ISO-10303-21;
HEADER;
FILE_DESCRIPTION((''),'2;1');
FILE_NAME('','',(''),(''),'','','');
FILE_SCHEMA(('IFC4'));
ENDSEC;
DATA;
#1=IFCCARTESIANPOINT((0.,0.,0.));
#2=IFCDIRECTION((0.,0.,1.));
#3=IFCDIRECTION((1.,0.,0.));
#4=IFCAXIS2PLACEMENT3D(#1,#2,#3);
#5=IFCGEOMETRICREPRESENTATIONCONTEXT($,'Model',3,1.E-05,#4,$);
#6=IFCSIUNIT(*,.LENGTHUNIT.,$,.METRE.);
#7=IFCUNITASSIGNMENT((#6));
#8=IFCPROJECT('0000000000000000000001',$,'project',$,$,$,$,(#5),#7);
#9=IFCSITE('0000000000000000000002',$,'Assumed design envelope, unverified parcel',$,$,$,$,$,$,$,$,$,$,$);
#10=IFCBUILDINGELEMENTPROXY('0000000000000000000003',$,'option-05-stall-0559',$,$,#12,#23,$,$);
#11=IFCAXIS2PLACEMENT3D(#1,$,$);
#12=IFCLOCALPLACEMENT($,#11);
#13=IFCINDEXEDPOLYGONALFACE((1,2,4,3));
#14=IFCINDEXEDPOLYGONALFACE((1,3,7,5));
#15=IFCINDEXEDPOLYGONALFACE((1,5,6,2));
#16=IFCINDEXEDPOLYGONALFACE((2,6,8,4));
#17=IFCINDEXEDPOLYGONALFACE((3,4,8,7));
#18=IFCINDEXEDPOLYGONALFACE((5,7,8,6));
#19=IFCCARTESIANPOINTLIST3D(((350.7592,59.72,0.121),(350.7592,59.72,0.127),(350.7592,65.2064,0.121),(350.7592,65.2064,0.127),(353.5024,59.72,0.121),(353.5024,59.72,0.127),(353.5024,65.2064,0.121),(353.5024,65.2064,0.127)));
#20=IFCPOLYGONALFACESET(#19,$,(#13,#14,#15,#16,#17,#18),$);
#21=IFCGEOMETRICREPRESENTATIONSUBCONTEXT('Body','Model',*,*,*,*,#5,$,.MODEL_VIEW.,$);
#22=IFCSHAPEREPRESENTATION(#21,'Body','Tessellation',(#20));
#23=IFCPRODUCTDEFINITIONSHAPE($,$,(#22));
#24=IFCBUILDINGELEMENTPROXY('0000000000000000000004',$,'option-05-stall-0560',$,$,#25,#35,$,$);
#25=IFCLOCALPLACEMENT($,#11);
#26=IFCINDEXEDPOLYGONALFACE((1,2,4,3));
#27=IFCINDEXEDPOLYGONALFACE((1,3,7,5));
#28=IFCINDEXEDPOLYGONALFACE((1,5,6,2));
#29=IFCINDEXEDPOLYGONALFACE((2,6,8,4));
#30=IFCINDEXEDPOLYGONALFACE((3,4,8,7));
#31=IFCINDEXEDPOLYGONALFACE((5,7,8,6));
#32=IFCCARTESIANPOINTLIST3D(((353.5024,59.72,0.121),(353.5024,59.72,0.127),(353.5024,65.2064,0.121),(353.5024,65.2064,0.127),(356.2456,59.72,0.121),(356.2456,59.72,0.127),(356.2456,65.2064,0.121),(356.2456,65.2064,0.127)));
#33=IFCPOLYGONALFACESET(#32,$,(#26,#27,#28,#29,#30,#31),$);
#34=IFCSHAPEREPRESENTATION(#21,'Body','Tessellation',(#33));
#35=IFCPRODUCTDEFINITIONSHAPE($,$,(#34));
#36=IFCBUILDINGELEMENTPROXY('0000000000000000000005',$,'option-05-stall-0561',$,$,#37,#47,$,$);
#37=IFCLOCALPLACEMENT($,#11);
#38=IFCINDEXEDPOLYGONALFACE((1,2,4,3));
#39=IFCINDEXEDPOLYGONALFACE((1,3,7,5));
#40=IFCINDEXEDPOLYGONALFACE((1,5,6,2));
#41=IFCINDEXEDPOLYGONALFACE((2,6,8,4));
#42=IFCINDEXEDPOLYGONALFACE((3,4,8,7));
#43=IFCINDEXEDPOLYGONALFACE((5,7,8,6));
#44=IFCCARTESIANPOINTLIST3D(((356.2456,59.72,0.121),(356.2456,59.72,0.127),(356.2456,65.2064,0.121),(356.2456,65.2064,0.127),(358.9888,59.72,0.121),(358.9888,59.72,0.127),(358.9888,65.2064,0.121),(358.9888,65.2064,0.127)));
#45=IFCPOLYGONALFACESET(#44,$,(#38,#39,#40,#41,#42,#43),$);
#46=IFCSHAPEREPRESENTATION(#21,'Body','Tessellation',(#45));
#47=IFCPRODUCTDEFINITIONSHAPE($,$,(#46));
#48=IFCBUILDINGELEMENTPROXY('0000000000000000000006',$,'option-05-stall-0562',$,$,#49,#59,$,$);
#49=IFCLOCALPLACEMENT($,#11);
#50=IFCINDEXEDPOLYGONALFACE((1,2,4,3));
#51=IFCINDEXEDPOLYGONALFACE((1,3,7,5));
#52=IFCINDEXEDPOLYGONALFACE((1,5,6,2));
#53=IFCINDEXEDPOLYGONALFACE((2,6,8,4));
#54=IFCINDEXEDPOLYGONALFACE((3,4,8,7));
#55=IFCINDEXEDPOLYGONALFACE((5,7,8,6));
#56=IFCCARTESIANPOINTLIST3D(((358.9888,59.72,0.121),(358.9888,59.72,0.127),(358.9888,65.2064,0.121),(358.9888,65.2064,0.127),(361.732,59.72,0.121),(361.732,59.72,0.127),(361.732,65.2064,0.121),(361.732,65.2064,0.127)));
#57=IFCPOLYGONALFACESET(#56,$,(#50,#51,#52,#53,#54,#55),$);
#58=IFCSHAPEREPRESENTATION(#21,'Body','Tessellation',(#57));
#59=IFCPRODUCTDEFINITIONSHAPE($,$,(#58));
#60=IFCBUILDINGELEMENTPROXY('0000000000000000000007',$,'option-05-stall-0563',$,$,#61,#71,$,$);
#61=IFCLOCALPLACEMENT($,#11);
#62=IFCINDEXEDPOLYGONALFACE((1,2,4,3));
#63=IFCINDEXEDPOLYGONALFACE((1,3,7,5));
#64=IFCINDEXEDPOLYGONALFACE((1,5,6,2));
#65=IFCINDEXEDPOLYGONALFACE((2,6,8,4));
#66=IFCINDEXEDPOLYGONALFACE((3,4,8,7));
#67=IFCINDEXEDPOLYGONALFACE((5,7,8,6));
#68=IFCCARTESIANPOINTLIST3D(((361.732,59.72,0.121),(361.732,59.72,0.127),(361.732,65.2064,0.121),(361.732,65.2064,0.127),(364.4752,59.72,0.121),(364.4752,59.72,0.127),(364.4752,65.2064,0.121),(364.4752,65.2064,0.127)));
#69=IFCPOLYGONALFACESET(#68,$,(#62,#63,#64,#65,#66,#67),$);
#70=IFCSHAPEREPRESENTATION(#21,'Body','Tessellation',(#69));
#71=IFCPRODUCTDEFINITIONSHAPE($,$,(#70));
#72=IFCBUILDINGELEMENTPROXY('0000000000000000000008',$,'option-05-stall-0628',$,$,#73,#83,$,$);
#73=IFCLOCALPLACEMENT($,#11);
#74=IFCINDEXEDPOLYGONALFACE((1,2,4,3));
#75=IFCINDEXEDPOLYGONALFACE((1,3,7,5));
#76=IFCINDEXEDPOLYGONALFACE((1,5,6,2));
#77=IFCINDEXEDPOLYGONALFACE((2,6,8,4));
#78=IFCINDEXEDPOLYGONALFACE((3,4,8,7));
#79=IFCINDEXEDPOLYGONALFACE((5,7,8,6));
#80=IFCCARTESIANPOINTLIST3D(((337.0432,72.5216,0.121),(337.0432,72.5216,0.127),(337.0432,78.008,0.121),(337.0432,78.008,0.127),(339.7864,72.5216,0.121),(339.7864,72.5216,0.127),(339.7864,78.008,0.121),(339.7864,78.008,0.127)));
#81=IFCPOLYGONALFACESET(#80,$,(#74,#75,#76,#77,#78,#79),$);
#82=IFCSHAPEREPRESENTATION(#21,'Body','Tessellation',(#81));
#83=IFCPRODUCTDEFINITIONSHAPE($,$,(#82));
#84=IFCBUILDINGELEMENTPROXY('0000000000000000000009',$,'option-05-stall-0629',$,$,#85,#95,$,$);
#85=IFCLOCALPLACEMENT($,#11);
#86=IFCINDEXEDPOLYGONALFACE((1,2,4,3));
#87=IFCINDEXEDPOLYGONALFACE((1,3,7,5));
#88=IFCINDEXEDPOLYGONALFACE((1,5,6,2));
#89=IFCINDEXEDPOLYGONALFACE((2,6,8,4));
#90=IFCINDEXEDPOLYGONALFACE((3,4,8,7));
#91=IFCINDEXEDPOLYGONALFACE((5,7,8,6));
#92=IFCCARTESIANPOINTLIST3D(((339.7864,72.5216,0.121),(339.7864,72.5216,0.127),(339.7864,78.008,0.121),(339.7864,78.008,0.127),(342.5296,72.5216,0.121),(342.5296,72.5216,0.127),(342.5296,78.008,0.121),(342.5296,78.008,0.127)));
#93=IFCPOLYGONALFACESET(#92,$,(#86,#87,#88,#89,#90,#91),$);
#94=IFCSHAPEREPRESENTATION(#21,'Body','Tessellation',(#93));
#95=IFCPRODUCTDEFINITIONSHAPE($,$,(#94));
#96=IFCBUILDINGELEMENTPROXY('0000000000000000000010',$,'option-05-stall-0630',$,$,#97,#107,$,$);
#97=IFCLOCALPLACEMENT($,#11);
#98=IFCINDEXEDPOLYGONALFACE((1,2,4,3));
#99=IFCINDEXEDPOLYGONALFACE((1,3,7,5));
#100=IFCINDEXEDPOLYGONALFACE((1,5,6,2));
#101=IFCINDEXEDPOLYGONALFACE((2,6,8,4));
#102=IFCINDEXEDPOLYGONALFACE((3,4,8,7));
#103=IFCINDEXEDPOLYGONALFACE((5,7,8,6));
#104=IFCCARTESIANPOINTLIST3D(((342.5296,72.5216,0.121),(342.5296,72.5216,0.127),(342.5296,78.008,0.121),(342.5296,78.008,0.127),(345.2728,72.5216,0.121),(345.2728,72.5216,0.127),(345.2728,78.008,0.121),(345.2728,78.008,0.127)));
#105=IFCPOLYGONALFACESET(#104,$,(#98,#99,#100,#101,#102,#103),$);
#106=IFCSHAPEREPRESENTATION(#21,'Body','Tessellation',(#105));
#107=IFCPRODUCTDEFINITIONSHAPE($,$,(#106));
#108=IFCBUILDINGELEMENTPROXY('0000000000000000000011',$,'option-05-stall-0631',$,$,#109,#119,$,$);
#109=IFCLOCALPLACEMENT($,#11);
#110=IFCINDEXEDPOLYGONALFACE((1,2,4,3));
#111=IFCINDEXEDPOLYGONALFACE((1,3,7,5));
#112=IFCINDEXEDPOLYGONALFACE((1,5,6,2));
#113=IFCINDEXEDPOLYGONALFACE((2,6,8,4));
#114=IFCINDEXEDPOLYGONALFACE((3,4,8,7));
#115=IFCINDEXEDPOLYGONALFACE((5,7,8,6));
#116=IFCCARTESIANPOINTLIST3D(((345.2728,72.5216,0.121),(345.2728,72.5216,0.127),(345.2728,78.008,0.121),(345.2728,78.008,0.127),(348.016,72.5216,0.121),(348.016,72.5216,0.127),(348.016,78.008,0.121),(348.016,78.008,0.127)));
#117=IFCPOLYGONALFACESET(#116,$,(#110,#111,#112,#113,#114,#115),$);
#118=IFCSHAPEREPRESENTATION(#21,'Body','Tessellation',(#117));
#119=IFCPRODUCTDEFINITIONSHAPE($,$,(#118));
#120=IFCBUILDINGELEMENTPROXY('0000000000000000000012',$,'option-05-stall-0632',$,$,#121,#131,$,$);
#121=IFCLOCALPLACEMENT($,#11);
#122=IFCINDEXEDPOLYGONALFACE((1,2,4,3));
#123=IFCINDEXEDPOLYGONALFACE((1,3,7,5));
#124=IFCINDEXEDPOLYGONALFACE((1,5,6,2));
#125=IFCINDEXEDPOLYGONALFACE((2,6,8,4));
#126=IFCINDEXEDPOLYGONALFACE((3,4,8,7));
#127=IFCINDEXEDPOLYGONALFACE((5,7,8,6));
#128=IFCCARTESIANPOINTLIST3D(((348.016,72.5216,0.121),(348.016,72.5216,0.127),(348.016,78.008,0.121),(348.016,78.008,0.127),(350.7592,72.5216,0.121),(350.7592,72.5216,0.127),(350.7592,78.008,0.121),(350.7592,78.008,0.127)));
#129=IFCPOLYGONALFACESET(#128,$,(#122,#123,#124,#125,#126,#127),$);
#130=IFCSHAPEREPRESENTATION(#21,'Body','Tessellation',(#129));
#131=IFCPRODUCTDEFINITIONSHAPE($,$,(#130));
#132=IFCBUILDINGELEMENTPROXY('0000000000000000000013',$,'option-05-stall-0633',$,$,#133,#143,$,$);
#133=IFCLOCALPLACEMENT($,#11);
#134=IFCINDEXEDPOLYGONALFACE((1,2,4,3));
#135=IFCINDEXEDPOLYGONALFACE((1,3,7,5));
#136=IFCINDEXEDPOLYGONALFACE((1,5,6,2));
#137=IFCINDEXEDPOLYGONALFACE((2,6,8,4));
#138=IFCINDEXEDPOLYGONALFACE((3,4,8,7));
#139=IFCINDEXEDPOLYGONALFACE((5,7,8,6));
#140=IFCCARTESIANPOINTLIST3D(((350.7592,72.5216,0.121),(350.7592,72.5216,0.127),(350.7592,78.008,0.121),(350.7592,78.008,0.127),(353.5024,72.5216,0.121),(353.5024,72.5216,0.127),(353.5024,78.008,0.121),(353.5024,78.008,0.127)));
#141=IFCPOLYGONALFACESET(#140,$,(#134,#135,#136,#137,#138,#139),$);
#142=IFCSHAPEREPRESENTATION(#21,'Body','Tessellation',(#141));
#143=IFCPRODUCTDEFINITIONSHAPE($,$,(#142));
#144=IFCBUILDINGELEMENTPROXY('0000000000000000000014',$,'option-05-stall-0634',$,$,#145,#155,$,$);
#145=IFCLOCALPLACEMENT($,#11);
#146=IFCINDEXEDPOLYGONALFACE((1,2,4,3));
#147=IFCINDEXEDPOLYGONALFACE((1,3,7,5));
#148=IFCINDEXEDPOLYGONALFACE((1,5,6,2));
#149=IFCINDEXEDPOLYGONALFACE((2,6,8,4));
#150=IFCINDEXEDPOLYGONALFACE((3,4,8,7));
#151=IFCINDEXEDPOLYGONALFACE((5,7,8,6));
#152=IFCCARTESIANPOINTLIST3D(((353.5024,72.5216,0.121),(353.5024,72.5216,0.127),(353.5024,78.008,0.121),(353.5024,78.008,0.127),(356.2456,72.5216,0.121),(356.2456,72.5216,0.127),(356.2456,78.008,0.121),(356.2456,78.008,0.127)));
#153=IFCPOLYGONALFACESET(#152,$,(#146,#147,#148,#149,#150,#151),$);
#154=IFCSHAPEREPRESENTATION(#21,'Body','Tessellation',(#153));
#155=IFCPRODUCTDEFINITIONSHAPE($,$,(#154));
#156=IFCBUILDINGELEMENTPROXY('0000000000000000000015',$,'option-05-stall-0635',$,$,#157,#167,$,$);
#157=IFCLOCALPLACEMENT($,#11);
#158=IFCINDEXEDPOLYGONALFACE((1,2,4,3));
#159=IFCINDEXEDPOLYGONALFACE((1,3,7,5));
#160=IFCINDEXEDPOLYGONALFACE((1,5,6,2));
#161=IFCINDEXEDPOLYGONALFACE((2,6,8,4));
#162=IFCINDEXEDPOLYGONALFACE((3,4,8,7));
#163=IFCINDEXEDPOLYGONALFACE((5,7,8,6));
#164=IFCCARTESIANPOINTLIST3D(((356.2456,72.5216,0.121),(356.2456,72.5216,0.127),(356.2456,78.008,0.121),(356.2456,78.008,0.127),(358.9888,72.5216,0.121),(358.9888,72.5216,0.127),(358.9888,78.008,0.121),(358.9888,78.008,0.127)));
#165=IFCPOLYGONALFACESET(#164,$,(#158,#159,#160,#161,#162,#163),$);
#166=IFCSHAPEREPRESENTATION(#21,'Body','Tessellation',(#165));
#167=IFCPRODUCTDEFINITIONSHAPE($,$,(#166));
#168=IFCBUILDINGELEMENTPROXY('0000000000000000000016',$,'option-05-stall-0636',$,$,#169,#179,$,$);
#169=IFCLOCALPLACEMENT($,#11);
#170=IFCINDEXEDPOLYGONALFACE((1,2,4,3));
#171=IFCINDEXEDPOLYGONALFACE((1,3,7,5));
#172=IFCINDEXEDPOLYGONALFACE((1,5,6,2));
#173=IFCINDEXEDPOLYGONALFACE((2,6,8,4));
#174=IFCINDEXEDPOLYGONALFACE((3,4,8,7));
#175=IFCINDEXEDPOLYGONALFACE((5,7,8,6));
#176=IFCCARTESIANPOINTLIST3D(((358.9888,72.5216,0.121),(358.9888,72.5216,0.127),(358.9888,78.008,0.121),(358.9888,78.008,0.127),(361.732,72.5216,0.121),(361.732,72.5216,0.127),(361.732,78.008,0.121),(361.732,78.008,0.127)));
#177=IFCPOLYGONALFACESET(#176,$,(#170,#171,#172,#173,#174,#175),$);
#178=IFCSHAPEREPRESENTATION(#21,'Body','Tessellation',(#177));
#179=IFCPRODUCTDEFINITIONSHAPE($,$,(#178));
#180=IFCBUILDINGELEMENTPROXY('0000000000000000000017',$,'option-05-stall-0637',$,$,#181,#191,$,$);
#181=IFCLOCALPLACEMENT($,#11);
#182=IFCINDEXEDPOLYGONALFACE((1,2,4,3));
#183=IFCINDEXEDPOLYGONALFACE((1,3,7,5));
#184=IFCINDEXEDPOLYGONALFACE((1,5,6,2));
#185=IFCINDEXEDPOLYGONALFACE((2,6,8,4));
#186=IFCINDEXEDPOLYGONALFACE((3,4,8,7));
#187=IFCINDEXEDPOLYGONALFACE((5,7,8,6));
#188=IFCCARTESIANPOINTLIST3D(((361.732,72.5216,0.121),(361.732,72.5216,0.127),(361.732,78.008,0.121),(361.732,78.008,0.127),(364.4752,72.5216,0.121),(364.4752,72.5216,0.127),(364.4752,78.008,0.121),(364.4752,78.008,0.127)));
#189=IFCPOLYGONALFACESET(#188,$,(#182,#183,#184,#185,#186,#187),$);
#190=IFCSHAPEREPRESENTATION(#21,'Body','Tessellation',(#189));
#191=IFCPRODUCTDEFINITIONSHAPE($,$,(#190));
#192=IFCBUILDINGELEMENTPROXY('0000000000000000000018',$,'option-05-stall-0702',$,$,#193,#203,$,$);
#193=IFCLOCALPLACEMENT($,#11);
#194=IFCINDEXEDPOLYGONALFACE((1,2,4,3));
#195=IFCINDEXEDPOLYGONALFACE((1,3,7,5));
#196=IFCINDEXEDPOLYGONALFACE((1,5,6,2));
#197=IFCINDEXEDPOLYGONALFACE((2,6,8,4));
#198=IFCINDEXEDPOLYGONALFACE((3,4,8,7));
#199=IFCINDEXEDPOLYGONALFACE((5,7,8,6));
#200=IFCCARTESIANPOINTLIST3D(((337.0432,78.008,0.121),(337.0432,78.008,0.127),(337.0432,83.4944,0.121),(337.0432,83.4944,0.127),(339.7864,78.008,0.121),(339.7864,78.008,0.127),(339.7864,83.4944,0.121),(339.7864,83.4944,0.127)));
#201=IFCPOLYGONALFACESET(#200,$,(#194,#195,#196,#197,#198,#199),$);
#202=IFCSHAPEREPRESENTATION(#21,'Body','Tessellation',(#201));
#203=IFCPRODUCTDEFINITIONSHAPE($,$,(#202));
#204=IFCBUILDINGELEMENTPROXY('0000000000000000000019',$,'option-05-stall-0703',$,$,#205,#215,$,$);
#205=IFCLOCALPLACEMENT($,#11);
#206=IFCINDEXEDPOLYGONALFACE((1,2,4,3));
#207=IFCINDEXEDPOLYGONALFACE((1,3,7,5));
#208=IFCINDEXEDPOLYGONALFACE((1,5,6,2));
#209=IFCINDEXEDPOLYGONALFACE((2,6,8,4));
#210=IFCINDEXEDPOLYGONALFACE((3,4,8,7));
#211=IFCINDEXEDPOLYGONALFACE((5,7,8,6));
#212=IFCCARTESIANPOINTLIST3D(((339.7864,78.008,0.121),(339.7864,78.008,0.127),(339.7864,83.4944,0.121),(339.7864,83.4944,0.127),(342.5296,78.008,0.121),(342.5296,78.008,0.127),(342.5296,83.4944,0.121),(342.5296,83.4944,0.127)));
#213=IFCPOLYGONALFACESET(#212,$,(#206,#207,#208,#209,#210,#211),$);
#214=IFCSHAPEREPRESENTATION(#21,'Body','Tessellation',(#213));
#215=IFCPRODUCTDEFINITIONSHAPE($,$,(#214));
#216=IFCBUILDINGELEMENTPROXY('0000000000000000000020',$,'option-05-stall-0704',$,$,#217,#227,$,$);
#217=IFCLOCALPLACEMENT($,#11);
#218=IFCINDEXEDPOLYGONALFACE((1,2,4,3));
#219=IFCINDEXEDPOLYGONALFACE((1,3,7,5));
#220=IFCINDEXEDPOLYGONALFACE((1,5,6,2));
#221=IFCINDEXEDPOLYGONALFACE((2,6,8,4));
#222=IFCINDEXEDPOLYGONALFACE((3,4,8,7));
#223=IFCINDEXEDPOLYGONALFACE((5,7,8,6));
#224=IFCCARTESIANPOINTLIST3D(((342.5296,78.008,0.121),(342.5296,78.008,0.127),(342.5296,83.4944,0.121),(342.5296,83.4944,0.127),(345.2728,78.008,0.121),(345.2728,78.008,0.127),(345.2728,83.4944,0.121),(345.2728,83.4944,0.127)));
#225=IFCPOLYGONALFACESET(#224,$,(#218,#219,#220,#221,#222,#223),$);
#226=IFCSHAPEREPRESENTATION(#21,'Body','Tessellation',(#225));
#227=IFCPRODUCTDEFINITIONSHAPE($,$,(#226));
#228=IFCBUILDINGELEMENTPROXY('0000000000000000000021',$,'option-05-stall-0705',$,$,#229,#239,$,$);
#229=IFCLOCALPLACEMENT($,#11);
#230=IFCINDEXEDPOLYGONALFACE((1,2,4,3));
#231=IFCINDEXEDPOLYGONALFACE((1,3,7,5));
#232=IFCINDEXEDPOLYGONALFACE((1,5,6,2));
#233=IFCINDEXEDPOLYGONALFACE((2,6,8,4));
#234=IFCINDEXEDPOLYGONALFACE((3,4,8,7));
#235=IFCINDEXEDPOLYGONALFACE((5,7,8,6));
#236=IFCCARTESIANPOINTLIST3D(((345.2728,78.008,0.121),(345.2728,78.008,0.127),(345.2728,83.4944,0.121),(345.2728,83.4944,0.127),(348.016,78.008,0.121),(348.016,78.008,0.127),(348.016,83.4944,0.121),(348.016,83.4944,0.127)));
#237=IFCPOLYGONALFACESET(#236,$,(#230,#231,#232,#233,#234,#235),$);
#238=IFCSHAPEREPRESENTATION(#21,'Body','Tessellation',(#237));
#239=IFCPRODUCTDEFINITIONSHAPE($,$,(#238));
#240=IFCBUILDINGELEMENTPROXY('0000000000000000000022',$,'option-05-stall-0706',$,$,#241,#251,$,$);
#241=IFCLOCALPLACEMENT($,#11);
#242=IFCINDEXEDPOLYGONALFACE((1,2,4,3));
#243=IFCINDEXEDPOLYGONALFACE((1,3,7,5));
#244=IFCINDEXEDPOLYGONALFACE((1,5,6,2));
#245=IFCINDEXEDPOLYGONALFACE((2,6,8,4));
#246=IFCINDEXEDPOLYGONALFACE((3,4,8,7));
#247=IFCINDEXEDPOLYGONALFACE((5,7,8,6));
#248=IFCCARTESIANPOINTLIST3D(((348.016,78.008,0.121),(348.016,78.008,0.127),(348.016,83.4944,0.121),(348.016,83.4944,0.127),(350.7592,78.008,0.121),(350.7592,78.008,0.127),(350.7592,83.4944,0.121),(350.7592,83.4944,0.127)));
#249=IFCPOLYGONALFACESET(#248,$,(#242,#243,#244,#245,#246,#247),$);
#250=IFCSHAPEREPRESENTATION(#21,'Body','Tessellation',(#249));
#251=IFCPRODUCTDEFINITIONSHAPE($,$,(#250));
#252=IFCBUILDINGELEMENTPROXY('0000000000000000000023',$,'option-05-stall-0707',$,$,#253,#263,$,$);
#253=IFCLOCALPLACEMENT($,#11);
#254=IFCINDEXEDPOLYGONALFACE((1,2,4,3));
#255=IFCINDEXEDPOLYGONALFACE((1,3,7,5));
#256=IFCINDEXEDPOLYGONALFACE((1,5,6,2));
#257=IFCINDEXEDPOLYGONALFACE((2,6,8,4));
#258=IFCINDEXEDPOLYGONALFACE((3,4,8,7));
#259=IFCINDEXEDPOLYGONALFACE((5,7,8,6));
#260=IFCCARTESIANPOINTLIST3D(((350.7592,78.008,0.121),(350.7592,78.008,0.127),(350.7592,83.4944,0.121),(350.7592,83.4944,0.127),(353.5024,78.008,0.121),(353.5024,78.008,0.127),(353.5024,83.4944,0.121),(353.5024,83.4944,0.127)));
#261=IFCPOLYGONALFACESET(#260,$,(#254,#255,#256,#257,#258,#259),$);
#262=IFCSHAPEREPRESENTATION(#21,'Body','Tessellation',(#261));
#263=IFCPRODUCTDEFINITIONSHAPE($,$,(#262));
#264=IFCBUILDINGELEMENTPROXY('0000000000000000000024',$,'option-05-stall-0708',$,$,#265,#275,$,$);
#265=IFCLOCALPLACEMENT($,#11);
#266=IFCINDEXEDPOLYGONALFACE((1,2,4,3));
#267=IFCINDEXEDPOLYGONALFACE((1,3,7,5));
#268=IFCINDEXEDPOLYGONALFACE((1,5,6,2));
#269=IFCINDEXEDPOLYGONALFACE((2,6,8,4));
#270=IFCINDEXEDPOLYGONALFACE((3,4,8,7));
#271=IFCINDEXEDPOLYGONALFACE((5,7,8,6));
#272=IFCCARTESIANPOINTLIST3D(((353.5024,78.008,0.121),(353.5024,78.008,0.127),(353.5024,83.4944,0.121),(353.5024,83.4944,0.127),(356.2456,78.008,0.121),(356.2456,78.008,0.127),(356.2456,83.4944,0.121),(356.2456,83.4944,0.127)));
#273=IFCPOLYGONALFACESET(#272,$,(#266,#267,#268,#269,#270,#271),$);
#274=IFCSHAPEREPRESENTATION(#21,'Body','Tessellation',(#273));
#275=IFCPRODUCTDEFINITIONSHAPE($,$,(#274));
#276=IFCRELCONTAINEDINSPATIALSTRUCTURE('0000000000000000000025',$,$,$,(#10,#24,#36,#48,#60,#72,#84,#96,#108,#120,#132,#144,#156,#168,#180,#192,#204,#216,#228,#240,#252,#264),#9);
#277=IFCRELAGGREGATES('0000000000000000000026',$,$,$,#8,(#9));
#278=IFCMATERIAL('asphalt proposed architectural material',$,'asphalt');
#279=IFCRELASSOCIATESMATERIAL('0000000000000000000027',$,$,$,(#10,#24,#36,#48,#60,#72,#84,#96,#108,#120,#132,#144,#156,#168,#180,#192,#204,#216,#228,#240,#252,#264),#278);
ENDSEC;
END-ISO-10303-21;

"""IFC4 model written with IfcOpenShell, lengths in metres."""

from ifc_helpers import new_model, si_unit, frame, origin_with_axes, place, context, subcontext, project, spatial, rectangle, extrude, material, element, save


model = new_model("IFC4")

# Units and contexts
model_context = context("Model", 3, precision=1e-05, world=origin_with_axes())
body_context = subcontext(model_context, "Body", "Model", "MODEL_VIEW")
ifc_project = project(units=[si_unit("LENGTHUNIT", "METRE")], contexts=[model_context])

# Site
site = spatial("IfcSite", under=ifc_project, Name="Assumed design envelope, unverified parcel")

# Building element proxies
ifc_material = material(Name="asphalt proposed architectural material", Category="asphalt")
for number, where, z_axis, x_axis, name in (
    (1, (352.1308, 62.4632, 0.121), (0.0, 0.0, 1.0), (1.0, 0.0, 0.0), "option-05-stall-0559"),
    (2, (354.874, 62.4632, 0.121), (0.0, 0.0, 1.0), (1.0, 0.0, 0.0), "option-05-stall-0560"),
    (3, (357.6172, 62.4632, 0.121), (0.0, 0.0, 1.0), (1.0, 0.0, 0.0), "option-05-stall-0561"),
    (4, (360.3604, 62.4632, 0.121), (0.0, 0.0, 1.0), (1.0, 0.0, 0.0), "option-05-stall-0562"),
    (5, (363.1036, 62.4632, 0.121), (0.0, 0.0, 1.0), (1.0, 0.0, 0.0), "option-05-stall-0563"),
    (6, (338.4148, 75.2648, 0.121), (0.0, 0.0, 1.0), (1.0, 0.0, 0.0), "option-05-stall-0628"),
    (7, (341.158, 75.2648, 0.121), (0.0, 0.0, 1.0), (1.0, 0.0, 0.0), "option-05-stall-0629"),
    (8, (343.9012, 75.2648, 0.121), (0.0, 0.0, 1.0), (1.0, 0.0, 0.0), "option-05-stall-0630"),
    (9, (346.6444, 75.2648, 0.121), (0.0, 0.0, 1.0), (1.0, 0.0, 0.0), "option-05-stall-0631"),
    (10, (349.3876, 75.2648, 0.121), (0.0, 0.0, 1.0), (1.0, 0.0, 0.0), "option-05-stall-0632"),
    (11, (352.1308, 75.2648, 0.121), (0.0, 0.0, 1.0), (1.0, 0.0, 0.0), "option-05-stall-0633"),
    (12, (354.874, 75.2648, 0.121), (0.0, 0.0, 1.0), (1.0, 0.0, 0.0), "option-05-stall-0634"),
    (13, (357.6172, 75.2648, 0.121), (0.0, 0.0, 1.0), (1.0, 0.0, 0.0), "option-05-stall-0635"),
    (14, (360.3604, 75.2648, 0.121), (0.0, 0.0, 1.0), (1.0, 0.0, 0.0), "option-05-stall-0636"),
    (15, (363.1036, 75.2648, 0.121), (0.0, 0.0, 1.0), (1.0, 0.0, 0.0), "option-05-stall-0637"),
    (16, (338.4148, 80.7512, 0.121), (0.0, 0.0, 1.0), (1.0, 0.0, 0.0), "option-05-stall-0702"),
    (17, (341.158, 80.7512, 0.121), (0.0, 0.0, 1.0), (1.0, 0.0, 0.0), "option-05-stall-0703"),
    (18, (343.9012, 80.7512, 0.121), (0.0, 0.0, 1.0), (1.0, 0.0, 0.0), "option-05-stall-0704"),
    (19, (346.6444, 80.7512, 0.121), (0.0, 0.0, 1.0), (1.0, 0.0, 0.0), "option-05-stall-0705"),
    (20, (349.3876, 80.7512, 0.121), (0.0, 0.0, 1.0), (1.0, 0.0, 0.0), "option-05-stall-0706"),
    (21, (352.1308, 80.7512, 0.121), (0.0, 0.0, 1.0), (1.0, 0.0, 0.0), "option-05-stall-0707"),
    (22, (354.874, 80.7512, 0.121), (0.0, 0.0, 1.0), (1.0, 0.0, 0.0), "option-05-stall-0708"),
):
    element("IfcBuildingElementProxy", number, at=place(None, frame(where, z_axis=z_axis, x_axis=x_axis)), inside=site, material=ifc_material, Name=name, context=body_context, shape_type="SweptSolid", body=[
        extrude(rectangle(XDim=2.7432, YDim=5.4864), origin_with_axes(), (0.0, 0.0, 1.0), 0.006),
    ])

save(model, "model.ifc")
